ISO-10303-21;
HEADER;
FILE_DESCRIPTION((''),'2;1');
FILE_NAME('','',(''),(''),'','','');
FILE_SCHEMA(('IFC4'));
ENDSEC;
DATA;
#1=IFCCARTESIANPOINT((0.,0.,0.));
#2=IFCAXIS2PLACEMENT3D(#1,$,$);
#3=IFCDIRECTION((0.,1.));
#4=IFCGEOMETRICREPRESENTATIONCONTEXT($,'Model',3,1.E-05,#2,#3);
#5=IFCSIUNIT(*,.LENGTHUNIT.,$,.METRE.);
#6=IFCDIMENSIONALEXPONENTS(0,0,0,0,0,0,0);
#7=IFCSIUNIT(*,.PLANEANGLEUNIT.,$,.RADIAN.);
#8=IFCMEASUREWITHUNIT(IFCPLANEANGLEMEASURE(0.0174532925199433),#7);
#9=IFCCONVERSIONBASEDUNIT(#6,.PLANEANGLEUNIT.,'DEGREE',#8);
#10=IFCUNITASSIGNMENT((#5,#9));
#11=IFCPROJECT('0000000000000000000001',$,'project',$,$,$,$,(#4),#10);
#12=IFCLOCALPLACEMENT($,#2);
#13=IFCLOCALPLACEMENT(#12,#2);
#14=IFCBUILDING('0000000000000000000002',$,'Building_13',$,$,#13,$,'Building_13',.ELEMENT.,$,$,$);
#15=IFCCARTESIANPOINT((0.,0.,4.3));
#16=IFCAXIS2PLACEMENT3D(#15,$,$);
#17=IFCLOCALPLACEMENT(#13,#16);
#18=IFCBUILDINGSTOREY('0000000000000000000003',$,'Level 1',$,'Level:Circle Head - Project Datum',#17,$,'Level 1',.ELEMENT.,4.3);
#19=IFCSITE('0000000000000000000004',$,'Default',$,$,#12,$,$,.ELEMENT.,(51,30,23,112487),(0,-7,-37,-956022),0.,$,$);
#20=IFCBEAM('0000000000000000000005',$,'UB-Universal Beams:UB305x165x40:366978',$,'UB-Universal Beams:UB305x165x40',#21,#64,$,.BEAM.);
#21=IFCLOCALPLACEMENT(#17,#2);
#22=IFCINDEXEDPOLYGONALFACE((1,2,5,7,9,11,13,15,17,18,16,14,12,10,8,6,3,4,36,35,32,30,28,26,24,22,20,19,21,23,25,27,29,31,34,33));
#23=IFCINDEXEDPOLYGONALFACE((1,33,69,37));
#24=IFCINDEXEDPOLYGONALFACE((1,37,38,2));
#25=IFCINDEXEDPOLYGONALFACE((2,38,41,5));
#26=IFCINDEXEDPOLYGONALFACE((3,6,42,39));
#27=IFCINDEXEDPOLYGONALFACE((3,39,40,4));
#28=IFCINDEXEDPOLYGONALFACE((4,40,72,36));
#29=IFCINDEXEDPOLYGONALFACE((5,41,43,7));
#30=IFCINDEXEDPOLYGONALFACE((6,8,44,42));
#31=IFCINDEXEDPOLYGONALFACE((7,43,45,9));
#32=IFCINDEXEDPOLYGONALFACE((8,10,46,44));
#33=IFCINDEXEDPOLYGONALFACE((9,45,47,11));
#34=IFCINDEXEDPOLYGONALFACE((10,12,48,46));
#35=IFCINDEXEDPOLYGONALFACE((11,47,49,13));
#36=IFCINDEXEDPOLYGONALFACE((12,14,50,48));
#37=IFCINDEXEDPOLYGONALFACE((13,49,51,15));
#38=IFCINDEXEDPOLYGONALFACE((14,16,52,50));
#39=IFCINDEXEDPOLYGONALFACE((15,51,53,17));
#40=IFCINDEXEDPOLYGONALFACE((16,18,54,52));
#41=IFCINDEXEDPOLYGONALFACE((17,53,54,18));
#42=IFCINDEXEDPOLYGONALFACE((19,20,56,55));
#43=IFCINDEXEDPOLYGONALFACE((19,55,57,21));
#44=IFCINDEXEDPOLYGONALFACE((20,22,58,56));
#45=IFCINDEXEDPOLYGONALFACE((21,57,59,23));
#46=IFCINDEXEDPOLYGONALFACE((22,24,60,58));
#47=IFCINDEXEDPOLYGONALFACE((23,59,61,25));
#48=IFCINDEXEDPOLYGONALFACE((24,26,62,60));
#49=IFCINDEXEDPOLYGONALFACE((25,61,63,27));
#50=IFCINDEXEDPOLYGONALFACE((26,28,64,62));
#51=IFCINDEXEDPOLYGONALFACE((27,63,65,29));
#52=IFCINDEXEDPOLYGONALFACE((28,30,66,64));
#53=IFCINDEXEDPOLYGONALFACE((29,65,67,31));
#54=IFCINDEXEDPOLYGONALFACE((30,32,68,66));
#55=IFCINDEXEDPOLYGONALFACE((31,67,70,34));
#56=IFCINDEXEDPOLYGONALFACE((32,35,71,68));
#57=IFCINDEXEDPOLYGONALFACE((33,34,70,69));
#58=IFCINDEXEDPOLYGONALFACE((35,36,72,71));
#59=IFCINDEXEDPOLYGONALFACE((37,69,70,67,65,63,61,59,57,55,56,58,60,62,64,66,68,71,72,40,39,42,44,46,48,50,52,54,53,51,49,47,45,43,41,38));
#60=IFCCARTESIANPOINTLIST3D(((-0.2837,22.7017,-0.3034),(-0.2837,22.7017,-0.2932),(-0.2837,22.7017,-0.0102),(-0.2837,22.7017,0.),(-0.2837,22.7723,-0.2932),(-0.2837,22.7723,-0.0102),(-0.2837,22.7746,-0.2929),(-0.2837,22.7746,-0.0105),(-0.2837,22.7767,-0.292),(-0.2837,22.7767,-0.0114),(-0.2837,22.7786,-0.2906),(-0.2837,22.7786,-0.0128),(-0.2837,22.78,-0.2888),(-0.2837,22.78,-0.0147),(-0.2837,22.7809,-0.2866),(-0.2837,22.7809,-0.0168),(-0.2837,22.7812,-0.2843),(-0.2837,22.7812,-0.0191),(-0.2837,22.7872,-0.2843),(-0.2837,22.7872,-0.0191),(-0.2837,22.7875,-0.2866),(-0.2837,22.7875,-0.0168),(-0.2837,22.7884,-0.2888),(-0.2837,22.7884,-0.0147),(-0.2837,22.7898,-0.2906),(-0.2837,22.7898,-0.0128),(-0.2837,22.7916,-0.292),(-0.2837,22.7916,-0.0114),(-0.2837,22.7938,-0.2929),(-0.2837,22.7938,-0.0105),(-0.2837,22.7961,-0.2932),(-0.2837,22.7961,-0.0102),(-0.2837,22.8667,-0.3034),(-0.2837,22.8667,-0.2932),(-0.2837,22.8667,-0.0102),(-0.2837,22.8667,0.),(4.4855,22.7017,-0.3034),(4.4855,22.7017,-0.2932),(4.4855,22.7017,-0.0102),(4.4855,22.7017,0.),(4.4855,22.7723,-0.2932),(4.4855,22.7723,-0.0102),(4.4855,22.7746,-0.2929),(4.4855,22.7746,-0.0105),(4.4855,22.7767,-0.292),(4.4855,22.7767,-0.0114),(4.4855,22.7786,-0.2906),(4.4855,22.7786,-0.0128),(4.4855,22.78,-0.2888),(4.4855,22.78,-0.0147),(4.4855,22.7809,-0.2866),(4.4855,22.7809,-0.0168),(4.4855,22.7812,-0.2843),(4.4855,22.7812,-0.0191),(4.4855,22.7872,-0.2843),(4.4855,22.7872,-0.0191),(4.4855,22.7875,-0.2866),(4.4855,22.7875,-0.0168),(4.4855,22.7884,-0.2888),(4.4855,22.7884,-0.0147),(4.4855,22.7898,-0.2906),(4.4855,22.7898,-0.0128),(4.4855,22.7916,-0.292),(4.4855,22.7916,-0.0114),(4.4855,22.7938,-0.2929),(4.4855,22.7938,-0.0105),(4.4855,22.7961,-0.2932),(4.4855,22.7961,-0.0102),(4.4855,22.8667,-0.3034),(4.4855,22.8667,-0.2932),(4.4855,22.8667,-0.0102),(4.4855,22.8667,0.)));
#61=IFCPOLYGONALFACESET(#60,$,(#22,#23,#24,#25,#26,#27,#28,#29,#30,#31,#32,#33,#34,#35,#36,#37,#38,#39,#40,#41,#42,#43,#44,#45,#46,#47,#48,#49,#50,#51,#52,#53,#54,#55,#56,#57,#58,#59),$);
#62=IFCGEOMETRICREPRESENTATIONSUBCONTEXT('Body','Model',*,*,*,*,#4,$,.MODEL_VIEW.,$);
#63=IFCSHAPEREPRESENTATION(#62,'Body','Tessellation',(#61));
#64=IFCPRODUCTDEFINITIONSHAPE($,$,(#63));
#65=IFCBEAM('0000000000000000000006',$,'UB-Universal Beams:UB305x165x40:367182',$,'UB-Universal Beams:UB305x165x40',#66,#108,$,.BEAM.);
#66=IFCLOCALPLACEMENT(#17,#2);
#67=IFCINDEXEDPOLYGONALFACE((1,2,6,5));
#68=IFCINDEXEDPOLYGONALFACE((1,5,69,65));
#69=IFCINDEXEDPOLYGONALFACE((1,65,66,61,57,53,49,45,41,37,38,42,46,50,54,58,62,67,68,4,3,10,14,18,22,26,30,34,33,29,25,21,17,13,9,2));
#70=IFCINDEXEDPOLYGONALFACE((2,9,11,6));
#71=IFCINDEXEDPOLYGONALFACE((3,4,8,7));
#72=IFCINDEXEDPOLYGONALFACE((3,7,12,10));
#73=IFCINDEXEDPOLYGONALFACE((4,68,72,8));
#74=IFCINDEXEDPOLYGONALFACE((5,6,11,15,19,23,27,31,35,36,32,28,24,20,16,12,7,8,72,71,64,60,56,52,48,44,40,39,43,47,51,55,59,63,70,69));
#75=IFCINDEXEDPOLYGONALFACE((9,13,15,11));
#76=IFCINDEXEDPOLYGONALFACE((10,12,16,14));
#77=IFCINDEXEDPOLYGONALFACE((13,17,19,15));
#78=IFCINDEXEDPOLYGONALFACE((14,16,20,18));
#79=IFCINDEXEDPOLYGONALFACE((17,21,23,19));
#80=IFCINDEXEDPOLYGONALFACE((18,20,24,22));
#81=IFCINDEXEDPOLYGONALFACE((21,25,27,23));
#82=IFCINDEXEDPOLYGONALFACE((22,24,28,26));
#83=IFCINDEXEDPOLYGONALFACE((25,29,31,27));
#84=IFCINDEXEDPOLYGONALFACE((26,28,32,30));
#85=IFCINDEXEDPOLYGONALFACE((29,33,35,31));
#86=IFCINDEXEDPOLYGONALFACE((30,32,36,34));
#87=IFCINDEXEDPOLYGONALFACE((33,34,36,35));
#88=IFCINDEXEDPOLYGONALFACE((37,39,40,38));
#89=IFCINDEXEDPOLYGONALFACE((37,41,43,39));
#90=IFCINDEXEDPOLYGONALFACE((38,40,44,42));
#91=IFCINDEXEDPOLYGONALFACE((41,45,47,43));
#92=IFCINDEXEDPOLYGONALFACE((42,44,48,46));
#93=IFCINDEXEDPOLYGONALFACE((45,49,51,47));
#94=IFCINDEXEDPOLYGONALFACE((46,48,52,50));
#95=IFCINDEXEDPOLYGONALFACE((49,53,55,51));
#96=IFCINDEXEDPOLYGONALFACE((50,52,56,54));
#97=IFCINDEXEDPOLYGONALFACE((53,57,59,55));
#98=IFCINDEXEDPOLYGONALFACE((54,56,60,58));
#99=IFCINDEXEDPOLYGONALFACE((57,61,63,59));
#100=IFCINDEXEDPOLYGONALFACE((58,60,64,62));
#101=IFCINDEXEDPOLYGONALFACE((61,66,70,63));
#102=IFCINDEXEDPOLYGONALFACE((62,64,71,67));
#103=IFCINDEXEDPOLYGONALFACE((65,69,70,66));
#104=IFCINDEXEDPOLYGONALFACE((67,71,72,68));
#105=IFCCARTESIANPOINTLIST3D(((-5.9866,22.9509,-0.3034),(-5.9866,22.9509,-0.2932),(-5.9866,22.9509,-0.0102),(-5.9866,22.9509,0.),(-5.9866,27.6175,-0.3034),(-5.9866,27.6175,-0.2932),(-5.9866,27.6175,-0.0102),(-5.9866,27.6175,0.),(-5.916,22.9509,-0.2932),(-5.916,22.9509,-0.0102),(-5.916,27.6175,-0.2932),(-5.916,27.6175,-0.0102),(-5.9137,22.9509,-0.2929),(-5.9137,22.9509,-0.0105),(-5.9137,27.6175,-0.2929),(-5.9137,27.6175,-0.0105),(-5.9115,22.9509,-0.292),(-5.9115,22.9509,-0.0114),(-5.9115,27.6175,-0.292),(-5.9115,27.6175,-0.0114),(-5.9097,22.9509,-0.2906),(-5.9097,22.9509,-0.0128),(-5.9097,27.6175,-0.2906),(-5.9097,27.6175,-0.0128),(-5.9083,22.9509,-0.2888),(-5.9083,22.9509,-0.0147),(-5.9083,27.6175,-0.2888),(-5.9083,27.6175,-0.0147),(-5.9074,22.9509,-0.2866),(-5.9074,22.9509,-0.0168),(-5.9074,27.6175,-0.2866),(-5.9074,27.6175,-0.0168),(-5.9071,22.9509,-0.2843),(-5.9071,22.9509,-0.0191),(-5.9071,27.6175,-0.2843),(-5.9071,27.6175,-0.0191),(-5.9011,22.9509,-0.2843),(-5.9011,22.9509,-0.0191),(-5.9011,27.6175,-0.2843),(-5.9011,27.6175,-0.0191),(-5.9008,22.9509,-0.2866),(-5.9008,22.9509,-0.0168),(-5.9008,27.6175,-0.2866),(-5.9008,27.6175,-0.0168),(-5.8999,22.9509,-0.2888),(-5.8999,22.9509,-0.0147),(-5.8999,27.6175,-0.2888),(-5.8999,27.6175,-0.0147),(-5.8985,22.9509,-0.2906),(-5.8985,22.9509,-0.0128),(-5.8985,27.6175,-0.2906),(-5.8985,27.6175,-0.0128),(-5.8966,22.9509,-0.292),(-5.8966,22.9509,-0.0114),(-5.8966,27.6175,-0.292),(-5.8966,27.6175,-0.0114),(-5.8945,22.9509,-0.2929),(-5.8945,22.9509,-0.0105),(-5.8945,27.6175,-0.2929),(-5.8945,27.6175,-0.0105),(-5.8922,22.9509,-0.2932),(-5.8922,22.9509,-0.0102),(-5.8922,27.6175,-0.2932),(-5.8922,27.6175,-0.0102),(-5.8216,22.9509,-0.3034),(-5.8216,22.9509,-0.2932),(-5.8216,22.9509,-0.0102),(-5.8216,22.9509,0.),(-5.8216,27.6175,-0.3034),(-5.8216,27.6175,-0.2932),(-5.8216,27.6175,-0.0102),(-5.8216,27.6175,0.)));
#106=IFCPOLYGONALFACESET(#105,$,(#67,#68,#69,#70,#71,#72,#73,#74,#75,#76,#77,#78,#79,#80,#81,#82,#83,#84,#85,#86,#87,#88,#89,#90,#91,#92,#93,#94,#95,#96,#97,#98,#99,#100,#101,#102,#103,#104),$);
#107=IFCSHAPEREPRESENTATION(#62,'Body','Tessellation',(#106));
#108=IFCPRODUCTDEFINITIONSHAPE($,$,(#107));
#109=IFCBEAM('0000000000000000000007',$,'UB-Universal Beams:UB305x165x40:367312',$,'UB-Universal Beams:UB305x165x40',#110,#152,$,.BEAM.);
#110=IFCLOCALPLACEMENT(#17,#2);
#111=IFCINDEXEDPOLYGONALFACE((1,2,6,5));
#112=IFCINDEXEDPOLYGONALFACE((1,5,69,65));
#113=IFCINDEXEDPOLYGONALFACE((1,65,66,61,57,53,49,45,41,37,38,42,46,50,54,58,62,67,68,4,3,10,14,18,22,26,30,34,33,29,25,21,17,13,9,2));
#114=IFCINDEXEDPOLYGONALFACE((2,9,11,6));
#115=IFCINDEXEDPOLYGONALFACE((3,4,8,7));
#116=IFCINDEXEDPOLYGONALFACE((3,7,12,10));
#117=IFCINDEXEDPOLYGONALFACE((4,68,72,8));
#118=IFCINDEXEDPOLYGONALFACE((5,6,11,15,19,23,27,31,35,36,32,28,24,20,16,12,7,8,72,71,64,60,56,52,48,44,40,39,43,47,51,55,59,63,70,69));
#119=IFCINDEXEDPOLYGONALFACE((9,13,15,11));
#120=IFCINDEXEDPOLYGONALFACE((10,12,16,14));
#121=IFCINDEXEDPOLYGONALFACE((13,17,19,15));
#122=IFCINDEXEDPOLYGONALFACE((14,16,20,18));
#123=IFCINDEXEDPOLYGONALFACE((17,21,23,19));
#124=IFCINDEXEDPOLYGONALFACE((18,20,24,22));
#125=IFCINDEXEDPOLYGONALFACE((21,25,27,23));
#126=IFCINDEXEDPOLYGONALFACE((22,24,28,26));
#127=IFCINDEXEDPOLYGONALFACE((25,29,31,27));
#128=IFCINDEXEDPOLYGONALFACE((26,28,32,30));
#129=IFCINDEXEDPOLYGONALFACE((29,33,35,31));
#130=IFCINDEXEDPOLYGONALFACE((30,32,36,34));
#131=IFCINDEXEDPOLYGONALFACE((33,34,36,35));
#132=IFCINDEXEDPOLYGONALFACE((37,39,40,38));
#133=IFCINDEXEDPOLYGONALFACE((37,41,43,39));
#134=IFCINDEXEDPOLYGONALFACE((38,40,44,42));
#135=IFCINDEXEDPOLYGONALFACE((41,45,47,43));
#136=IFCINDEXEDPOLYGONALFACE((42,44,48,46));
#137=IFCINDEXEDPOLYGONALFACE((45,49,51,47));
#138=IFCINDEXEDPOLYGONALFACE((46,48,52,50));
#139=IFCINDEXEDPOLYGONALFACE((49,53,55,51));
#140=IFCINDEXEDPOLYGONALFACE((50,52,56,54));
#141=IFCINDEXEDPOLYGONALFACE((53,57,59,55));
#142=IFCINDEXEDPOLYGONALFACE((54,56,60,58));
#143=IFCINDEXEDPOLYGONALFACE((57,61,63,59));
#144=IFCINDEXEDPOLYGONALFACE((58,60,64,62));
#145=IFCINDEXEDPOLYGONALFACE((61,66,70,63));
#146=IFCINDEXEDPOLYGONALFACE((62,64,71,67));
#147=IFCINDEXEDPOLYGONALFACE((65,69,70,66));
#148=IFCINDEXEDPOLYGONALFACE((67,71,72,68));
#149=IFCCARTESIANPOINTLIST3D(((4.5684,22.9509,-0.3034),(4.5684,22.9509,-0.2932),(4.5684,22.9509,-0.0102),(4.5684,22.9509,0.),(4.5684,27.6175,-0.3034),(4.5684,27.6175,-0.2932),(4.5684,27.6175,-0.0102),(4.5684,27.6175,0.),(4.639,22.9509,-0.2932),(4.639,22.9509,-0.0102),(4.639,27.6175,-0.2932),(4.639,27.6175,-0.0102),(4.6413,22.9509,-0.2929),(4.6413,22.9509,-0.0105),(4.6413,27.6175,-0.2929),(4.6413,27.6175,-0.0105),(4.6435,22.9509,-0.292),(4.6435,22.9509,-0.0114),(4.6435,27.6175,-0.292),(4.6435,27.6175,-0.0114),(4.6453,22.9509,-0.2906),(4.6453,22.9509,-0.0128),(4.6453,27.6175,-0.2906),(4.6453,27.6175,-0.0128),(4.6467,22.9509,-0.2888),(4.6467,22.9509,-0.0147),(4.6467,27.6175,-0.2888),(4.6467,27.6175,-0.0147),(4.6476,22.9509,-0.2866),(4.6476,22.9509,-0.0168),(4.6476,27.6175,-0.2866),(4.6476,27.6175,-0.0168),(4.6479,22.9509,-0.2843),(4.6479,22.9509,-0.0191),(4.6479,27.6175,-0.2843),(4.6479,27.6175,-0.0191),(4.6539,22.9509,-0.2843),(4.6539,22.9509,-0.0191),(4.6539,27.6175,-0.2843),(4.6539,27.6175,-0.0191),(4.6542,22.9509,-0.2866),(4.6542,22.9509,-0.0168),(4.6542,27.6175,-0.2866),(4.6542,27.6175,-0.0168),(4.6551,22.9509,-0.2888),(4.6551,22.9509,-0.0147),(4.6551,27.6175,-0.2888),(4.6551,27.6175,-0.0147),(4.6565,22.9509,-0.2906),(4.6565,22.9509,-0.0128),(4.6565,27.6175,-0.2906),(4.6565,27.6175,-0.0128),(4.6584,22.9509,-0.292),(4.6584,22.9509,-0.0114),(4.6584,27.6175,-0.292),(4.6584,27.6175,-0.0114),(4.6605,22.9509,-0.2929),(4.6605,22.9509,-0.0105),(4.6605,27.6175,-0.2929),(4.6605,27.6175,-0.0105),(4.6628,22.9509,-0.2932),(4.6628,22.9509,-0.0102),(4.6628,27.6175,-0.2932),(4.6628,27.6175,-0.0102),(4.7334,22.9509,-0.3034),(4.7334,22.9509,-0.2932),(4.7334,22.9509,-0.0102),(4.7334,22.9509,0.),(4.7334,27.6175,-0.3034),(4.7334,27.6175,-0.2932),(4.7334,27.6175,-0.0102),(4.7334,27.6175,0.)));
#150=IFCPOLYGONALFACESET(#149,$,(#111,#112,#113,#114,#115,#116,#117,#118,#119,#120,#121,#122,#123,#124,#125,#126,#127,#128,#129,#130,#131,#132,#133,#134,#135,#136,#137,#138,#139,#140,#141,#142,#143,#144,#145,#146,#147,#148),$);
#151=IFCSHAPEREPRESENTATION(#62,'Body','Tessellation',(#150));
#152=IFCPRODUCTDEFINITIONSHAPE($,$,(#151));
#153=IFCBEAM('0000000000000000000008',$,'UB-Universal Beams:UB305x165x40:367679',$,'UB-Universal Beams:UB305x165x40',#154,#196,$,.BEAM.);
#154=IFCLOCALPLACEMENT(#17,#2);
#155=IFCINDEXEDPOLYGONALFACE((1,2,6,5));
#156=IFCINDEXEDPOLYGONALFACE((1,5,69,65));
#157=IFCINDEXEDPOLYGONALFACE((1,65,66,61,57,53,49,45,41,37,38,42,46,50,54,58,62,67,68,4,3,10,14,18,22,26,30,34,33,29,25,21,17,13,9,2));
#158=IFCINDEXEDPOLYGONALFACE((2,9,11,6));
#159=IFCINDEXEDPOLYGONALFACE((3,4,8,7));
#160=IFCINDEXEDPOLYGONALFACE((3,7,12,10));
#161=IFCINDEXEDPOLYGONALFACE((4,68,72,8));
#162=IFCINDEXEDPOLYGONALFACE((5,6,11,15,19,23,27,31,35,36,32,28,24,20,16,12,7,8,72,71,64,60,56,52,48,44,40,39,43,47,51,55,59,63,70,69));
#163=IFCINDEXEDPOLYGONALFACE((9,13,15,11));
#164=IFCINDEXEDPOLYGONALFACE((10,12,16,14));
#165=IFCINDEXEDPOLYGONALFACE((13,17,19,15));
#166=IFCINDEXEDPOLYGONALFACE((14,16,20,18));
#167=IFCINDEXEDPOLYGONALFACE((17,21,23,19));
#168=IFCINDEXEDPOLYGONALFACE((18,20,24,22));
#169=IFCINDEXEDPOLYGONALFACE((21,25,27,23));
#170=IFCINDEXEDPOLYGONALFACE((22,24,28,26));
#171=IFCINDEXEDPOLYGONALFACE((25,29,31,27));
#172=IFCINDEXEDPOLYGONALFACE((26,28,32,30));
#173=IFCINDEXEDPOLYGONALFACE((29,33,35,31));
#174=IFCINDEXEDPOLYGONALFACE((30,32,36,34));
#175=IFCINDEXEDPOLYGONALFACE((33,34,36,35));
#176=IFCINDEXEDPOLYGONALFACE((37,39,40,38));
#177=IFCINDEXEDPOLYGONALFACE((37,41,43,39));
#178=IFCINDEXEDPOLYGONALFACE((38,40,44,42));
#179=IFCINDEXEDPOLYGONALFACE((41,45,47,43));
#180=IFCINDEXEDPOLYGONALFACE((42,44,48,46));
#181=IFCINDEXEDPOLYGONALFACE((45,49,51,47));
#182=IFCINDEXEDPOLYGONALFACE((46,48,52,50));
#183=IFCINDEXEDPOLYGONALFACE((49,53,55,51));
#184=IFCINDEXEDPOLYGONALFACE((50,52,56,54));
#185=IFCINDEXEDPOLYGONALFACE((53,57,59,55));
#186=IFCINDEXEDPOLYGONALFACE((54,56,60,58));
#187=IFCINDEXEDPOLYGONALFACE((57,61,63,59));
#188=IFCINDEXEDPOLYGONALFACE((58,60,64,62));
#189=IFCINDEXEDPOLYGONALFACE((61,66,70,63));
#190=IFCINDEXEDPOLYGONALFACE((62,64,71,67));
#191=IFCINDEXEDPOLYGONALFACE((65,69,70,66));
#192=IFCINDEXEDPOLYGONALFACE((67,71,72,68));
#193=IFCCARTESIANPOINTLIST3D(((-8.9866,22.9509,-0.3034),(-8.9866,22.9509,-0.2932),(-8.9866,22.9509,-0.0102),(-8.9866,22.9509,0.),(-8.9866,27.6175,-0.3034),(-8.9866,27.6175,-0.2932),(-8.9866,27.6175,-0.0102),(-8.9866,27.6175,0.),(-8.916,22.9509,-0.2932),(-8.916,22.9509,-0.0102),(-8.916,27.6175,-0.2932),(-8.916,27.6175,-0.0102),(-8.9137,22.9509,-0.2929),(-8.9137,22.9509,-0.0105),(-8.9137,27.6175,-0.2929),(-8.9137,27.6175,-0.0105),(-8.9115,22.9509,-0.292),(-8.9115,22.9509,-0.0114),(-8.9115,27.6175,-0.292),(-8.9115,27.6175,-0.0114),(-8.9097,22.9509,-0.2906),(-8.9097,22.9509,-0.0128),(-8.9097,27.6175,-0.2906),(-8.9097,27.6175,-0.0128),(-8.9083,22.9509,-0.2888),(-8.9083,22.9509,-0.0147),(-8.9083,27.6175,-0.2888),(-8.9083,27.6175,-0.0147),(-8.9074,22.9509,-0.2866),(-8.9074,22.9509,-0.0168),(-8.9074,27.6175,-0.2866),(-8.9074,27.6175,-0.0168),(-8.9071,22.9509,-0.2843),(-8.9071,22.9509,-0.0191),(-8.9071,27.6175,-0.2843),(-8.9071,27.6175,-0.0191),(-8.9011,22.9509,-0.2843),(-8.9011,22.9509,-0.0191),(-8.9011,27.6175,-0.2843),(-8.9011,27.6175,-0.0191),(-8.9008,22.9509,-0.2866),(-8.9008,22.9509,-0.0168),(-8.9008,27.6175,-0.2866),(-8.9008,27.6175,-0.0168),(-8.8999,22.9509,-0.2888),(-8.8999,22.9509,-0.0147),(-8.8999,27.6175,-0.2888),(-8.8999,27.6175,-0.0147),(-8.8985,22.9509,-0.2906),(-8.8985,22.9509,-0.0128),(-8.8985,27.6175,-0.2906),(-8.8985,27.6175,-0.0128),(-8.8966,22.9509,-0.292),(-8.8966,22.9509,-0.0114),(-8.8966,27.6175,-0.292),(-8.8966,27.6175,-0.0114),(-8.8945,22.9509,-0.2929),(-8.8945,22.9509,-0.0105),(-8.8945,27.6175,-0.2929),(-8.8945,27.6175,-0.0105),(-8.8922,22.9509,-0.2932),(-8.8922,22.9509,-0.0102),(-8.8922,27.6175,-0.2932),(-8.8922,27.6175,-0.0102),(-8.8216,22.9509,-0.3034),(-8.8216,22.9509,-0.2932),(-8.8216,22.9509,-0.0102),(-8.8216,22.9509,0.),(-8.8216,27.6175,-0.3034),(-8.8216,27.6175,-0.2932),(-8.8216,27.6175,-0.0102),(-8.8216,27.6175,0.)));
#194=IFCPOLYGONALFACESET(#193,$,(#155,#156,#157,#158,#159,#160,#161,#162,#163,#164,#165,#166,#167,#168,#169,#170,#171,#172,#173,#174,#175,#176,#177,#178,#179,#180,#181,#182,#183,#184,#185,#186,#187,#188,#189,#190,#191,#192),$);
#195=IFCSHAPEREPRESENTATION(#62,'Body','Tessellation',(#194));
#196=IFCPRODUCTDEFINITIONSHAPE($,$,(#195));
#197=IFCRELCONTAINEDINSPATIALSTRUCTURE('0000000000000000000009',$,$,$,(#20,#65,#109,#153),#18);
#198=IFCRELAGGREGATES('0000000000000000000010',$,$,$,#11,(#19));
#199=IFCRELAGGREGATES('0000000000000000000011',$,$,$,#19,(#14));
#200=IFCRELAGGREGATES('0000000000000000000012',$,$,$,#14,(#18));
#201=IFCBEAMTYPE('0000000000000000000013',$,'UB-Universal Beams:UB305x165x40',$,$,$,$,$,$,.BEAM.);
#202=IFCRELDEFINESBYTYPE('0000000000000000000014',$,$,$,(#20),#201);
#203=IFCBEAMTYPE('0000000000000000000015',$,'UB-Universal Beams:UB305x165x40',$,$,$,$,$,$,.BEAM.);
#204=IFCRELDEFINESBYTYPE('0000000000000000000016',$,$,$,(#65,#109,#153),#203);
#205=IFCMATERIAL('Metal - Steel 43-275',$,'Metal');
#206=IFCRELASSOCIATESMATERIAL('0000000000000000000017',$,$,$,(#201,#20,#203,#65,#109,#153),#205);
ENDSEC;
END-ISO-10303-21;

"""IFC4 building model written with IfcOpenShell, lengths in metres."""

from ifc_helpers import new_model, entity, si_unit, converted_unit, direction, frame, origin, place, context, subcontext, project, spatial, line, arc, indexed_curve, outline, extrude, source, transform, mapped, material, type_object, type_shapes, element, save


model = new_model("IFC4")

# Units and contexts
model_context = context("Model", 3, precision=1e-05, world=origin(), true_north=direction((0.0, 1.0)))
body_context = subcontext(model_context, "Body", "Model", "MODEL_VIEW")
ifc_project = project(units=[si_unit("LENGTHUNIT", "METRE"), converted_unit("PLANEANGLEUNIT", "DEGREE", entity("IfcPlaneAngleMeasure", 0.0174532925199433), si_unit("PLANEANGLEUNIT", "RADIAN"), dimensions=[0, 0, 0, 0, 0, 0, 0])], contexts=[model_context])

# Site, building, storey
site_placement = place(None, origin())
site = spatial("IfcSite", under=ifc_project, at=site_placement, Name="Default", CompositionType="ELEMENT", RefLatitude=(51, 30, 23, 112487), RefLongitude=(0, -7, -37, -956022), RefElevation=0.0)
building_placement = place(site_placement, origin())
building = spatial("IfcBuilding", under=site, at=building_placement, Name="Building_13", LongName="Building_13", CompositionType="ELEMENT")
storey_placement = place(building_placement, frame((0.0, 0.0, 4.3)))
storey = spatial("IfcBuildingStorey", under=building, at=storey_placement, Name="Level 1", ObjectType="Level:Circle Head - Project Datum", LongName="Level 1", CompositionType="ELEMENT", Elevation=4.3)

# Beams
ifc_material_1 = material(Name="Metal - Steel 43-275", Category="Metal")
beam_type_1 = type_object("IfcBeamType", Name="UB-Universal Beams:UB305x165x40", PredefinedType="BEAM", material=ifc_material_1)
shared_shape_1 = source(origin(), body_context, "Body", "SweptSolid", [
    extrude(outline(indexed_curve([(-0.0825, -0.1415), (-0.0825, -0.1517), (0.0825, -0.1517), (0.0825, -0.1415), (0.0119, -0.1415), (0.0056, -0.1389), (0.003, -0.1326), (0.003, 0.1326), (0.0056, 0.1389), (0.0119, 0.1415), (0.0825, 0.1415), (0.0825, 0.1517), (-0.0825, 0.1517), (-0.0825, 0.1415), (-0.0119, 0.1415), (-0.0056, 0.1389), (-0.003, 0.1326), (-0.003, -0.1326), (-0.0056, -0.1389), (-0.0119, -0.1415)], segments=[line(1, 2, 3, 4, 5), arc(5, 6, 7), line(7, 8), arc(8, 9, 10), line(10, 11, 12, 13, 14, 15), arc(15, 16, 17), line(17, 18), arc(18, 19, 20), line(20, 1)], self_intersect=False)), frame((-2.3846, 0.0, 0.0), z_axis=(-1.0, 0.0, 0.0), x_axis=(0.0, -1.0, 0.0)), (0.0, 0.0, -1.0), 4.7692),
])
type_shapes(beam_type_1, [shared_shape_1])
beam_1_placement = place(storey_placement, frame((2.1009, 22.7842, -0.1517), z_axis=(0.0, 0.0, 1.0), x_axis=(-1.0, 0.0, 0.0)))
element("IfcBeam", 1, at=beam_1_placement, inside=storey, type_object=beam_type_1, material=ifc_material_1, Name="UB-Universal Beams:UB305x165x40:366978", ObjectType="UB-Universal Beams:UB305x165x40", PredefinedType="BEAM", context=body_context, shape_type="MappedRepresentation", body=[
    mapped(shared_shape_1, transform((0.0, 0.0, 0.0), scale=1.0)),
])
beam_type_2 = type_object("IfcBeamType", Name="UB-Universal Beams:UB305x165x40", PredefinedType="BEAM", material=ifc_material_1)
shared_shape_2 = source(origin(), body_context, "Body", "SweptSolid", [
    extrude(outline(indexed_curve([(-0.0825, -0.1415), (-0.0825, -0.1517), (0.0825, -0.1517), (0.0825, -0.1415), (0.0119, -0.1415), (0.0056, -0.1389), (0.003, -0.1326), (0.003, 0.1326), (0.0056, 0.1389), (0.0119, 0.1415), (0.0825, 0.1415), (0.0825, 0.1517), (-0.0825, 0.1517), (-0.0825, 0.1415), (-0.0119, 0.1415), (-0.0056, 0.1389), (-0.003, 0.1326), (-0.003, -0.1326), (-0.0056, -0.1389), (-0.0119, -0.1415)], segments=[line(1, 2, 3, 4, 5), arc(5, 6, 7), line(7, 8), arc(8, 9, 10), line(10, 11, 12, 13, 14, 15), arc(15, 16, 17), line(17, 18), arc(18, 19, 20), line(20, 1)], self_intersect=False)), frame((-2.3333, 0.0, 0.0), z_axis=(-1.0, 0.0, 0.0), x_axis=(0.0, -1.0, 0.0)), (0.0, 0.0, -1.0), 4.6666),
])
type_shapes(beam_type_2, [shared_shape_2])
for number, where, z_axis, x_axis, name in (
    (2, (-5.9041, 25.2842, -0.1517), (0.0, 0.0, 1.0), (0.0, -1.0, 0.0), "UB-Universal Beams:UB305x165x40:367182"),
    (3, (4.6509, 25.2842, -0.1517), (0.0, 0.0, 1.0), (0.0, -1.0, 0.0), "UB-Universal Beams:UB305x165x40:367312"),
    (4, (-8.9041, 25.2842, -0.1517), (0.0, 0.0, 1.0), (0.0, -1.0, 0.0), "UB-Universal Beams:UB305x165x40:367679"),
):
    element("IfcBeam", number, at=place(storey_placement, frame(where, z_axis=z_axis, x_axis=x_axis)), inside=storey, type_object=beam_type_2, material=ifc_material_1, Name=name, ObjectType="UB-Universal Beams:UB305x165x40", PredefinedType="BEAM", context=body_context, shape_type="MappedRepresentation", body=[
        mapped(shared_shape_2, transform((0.0, 0.0, 0.0), scale=1.0)),
    ])

save(model, "model.ifc")
